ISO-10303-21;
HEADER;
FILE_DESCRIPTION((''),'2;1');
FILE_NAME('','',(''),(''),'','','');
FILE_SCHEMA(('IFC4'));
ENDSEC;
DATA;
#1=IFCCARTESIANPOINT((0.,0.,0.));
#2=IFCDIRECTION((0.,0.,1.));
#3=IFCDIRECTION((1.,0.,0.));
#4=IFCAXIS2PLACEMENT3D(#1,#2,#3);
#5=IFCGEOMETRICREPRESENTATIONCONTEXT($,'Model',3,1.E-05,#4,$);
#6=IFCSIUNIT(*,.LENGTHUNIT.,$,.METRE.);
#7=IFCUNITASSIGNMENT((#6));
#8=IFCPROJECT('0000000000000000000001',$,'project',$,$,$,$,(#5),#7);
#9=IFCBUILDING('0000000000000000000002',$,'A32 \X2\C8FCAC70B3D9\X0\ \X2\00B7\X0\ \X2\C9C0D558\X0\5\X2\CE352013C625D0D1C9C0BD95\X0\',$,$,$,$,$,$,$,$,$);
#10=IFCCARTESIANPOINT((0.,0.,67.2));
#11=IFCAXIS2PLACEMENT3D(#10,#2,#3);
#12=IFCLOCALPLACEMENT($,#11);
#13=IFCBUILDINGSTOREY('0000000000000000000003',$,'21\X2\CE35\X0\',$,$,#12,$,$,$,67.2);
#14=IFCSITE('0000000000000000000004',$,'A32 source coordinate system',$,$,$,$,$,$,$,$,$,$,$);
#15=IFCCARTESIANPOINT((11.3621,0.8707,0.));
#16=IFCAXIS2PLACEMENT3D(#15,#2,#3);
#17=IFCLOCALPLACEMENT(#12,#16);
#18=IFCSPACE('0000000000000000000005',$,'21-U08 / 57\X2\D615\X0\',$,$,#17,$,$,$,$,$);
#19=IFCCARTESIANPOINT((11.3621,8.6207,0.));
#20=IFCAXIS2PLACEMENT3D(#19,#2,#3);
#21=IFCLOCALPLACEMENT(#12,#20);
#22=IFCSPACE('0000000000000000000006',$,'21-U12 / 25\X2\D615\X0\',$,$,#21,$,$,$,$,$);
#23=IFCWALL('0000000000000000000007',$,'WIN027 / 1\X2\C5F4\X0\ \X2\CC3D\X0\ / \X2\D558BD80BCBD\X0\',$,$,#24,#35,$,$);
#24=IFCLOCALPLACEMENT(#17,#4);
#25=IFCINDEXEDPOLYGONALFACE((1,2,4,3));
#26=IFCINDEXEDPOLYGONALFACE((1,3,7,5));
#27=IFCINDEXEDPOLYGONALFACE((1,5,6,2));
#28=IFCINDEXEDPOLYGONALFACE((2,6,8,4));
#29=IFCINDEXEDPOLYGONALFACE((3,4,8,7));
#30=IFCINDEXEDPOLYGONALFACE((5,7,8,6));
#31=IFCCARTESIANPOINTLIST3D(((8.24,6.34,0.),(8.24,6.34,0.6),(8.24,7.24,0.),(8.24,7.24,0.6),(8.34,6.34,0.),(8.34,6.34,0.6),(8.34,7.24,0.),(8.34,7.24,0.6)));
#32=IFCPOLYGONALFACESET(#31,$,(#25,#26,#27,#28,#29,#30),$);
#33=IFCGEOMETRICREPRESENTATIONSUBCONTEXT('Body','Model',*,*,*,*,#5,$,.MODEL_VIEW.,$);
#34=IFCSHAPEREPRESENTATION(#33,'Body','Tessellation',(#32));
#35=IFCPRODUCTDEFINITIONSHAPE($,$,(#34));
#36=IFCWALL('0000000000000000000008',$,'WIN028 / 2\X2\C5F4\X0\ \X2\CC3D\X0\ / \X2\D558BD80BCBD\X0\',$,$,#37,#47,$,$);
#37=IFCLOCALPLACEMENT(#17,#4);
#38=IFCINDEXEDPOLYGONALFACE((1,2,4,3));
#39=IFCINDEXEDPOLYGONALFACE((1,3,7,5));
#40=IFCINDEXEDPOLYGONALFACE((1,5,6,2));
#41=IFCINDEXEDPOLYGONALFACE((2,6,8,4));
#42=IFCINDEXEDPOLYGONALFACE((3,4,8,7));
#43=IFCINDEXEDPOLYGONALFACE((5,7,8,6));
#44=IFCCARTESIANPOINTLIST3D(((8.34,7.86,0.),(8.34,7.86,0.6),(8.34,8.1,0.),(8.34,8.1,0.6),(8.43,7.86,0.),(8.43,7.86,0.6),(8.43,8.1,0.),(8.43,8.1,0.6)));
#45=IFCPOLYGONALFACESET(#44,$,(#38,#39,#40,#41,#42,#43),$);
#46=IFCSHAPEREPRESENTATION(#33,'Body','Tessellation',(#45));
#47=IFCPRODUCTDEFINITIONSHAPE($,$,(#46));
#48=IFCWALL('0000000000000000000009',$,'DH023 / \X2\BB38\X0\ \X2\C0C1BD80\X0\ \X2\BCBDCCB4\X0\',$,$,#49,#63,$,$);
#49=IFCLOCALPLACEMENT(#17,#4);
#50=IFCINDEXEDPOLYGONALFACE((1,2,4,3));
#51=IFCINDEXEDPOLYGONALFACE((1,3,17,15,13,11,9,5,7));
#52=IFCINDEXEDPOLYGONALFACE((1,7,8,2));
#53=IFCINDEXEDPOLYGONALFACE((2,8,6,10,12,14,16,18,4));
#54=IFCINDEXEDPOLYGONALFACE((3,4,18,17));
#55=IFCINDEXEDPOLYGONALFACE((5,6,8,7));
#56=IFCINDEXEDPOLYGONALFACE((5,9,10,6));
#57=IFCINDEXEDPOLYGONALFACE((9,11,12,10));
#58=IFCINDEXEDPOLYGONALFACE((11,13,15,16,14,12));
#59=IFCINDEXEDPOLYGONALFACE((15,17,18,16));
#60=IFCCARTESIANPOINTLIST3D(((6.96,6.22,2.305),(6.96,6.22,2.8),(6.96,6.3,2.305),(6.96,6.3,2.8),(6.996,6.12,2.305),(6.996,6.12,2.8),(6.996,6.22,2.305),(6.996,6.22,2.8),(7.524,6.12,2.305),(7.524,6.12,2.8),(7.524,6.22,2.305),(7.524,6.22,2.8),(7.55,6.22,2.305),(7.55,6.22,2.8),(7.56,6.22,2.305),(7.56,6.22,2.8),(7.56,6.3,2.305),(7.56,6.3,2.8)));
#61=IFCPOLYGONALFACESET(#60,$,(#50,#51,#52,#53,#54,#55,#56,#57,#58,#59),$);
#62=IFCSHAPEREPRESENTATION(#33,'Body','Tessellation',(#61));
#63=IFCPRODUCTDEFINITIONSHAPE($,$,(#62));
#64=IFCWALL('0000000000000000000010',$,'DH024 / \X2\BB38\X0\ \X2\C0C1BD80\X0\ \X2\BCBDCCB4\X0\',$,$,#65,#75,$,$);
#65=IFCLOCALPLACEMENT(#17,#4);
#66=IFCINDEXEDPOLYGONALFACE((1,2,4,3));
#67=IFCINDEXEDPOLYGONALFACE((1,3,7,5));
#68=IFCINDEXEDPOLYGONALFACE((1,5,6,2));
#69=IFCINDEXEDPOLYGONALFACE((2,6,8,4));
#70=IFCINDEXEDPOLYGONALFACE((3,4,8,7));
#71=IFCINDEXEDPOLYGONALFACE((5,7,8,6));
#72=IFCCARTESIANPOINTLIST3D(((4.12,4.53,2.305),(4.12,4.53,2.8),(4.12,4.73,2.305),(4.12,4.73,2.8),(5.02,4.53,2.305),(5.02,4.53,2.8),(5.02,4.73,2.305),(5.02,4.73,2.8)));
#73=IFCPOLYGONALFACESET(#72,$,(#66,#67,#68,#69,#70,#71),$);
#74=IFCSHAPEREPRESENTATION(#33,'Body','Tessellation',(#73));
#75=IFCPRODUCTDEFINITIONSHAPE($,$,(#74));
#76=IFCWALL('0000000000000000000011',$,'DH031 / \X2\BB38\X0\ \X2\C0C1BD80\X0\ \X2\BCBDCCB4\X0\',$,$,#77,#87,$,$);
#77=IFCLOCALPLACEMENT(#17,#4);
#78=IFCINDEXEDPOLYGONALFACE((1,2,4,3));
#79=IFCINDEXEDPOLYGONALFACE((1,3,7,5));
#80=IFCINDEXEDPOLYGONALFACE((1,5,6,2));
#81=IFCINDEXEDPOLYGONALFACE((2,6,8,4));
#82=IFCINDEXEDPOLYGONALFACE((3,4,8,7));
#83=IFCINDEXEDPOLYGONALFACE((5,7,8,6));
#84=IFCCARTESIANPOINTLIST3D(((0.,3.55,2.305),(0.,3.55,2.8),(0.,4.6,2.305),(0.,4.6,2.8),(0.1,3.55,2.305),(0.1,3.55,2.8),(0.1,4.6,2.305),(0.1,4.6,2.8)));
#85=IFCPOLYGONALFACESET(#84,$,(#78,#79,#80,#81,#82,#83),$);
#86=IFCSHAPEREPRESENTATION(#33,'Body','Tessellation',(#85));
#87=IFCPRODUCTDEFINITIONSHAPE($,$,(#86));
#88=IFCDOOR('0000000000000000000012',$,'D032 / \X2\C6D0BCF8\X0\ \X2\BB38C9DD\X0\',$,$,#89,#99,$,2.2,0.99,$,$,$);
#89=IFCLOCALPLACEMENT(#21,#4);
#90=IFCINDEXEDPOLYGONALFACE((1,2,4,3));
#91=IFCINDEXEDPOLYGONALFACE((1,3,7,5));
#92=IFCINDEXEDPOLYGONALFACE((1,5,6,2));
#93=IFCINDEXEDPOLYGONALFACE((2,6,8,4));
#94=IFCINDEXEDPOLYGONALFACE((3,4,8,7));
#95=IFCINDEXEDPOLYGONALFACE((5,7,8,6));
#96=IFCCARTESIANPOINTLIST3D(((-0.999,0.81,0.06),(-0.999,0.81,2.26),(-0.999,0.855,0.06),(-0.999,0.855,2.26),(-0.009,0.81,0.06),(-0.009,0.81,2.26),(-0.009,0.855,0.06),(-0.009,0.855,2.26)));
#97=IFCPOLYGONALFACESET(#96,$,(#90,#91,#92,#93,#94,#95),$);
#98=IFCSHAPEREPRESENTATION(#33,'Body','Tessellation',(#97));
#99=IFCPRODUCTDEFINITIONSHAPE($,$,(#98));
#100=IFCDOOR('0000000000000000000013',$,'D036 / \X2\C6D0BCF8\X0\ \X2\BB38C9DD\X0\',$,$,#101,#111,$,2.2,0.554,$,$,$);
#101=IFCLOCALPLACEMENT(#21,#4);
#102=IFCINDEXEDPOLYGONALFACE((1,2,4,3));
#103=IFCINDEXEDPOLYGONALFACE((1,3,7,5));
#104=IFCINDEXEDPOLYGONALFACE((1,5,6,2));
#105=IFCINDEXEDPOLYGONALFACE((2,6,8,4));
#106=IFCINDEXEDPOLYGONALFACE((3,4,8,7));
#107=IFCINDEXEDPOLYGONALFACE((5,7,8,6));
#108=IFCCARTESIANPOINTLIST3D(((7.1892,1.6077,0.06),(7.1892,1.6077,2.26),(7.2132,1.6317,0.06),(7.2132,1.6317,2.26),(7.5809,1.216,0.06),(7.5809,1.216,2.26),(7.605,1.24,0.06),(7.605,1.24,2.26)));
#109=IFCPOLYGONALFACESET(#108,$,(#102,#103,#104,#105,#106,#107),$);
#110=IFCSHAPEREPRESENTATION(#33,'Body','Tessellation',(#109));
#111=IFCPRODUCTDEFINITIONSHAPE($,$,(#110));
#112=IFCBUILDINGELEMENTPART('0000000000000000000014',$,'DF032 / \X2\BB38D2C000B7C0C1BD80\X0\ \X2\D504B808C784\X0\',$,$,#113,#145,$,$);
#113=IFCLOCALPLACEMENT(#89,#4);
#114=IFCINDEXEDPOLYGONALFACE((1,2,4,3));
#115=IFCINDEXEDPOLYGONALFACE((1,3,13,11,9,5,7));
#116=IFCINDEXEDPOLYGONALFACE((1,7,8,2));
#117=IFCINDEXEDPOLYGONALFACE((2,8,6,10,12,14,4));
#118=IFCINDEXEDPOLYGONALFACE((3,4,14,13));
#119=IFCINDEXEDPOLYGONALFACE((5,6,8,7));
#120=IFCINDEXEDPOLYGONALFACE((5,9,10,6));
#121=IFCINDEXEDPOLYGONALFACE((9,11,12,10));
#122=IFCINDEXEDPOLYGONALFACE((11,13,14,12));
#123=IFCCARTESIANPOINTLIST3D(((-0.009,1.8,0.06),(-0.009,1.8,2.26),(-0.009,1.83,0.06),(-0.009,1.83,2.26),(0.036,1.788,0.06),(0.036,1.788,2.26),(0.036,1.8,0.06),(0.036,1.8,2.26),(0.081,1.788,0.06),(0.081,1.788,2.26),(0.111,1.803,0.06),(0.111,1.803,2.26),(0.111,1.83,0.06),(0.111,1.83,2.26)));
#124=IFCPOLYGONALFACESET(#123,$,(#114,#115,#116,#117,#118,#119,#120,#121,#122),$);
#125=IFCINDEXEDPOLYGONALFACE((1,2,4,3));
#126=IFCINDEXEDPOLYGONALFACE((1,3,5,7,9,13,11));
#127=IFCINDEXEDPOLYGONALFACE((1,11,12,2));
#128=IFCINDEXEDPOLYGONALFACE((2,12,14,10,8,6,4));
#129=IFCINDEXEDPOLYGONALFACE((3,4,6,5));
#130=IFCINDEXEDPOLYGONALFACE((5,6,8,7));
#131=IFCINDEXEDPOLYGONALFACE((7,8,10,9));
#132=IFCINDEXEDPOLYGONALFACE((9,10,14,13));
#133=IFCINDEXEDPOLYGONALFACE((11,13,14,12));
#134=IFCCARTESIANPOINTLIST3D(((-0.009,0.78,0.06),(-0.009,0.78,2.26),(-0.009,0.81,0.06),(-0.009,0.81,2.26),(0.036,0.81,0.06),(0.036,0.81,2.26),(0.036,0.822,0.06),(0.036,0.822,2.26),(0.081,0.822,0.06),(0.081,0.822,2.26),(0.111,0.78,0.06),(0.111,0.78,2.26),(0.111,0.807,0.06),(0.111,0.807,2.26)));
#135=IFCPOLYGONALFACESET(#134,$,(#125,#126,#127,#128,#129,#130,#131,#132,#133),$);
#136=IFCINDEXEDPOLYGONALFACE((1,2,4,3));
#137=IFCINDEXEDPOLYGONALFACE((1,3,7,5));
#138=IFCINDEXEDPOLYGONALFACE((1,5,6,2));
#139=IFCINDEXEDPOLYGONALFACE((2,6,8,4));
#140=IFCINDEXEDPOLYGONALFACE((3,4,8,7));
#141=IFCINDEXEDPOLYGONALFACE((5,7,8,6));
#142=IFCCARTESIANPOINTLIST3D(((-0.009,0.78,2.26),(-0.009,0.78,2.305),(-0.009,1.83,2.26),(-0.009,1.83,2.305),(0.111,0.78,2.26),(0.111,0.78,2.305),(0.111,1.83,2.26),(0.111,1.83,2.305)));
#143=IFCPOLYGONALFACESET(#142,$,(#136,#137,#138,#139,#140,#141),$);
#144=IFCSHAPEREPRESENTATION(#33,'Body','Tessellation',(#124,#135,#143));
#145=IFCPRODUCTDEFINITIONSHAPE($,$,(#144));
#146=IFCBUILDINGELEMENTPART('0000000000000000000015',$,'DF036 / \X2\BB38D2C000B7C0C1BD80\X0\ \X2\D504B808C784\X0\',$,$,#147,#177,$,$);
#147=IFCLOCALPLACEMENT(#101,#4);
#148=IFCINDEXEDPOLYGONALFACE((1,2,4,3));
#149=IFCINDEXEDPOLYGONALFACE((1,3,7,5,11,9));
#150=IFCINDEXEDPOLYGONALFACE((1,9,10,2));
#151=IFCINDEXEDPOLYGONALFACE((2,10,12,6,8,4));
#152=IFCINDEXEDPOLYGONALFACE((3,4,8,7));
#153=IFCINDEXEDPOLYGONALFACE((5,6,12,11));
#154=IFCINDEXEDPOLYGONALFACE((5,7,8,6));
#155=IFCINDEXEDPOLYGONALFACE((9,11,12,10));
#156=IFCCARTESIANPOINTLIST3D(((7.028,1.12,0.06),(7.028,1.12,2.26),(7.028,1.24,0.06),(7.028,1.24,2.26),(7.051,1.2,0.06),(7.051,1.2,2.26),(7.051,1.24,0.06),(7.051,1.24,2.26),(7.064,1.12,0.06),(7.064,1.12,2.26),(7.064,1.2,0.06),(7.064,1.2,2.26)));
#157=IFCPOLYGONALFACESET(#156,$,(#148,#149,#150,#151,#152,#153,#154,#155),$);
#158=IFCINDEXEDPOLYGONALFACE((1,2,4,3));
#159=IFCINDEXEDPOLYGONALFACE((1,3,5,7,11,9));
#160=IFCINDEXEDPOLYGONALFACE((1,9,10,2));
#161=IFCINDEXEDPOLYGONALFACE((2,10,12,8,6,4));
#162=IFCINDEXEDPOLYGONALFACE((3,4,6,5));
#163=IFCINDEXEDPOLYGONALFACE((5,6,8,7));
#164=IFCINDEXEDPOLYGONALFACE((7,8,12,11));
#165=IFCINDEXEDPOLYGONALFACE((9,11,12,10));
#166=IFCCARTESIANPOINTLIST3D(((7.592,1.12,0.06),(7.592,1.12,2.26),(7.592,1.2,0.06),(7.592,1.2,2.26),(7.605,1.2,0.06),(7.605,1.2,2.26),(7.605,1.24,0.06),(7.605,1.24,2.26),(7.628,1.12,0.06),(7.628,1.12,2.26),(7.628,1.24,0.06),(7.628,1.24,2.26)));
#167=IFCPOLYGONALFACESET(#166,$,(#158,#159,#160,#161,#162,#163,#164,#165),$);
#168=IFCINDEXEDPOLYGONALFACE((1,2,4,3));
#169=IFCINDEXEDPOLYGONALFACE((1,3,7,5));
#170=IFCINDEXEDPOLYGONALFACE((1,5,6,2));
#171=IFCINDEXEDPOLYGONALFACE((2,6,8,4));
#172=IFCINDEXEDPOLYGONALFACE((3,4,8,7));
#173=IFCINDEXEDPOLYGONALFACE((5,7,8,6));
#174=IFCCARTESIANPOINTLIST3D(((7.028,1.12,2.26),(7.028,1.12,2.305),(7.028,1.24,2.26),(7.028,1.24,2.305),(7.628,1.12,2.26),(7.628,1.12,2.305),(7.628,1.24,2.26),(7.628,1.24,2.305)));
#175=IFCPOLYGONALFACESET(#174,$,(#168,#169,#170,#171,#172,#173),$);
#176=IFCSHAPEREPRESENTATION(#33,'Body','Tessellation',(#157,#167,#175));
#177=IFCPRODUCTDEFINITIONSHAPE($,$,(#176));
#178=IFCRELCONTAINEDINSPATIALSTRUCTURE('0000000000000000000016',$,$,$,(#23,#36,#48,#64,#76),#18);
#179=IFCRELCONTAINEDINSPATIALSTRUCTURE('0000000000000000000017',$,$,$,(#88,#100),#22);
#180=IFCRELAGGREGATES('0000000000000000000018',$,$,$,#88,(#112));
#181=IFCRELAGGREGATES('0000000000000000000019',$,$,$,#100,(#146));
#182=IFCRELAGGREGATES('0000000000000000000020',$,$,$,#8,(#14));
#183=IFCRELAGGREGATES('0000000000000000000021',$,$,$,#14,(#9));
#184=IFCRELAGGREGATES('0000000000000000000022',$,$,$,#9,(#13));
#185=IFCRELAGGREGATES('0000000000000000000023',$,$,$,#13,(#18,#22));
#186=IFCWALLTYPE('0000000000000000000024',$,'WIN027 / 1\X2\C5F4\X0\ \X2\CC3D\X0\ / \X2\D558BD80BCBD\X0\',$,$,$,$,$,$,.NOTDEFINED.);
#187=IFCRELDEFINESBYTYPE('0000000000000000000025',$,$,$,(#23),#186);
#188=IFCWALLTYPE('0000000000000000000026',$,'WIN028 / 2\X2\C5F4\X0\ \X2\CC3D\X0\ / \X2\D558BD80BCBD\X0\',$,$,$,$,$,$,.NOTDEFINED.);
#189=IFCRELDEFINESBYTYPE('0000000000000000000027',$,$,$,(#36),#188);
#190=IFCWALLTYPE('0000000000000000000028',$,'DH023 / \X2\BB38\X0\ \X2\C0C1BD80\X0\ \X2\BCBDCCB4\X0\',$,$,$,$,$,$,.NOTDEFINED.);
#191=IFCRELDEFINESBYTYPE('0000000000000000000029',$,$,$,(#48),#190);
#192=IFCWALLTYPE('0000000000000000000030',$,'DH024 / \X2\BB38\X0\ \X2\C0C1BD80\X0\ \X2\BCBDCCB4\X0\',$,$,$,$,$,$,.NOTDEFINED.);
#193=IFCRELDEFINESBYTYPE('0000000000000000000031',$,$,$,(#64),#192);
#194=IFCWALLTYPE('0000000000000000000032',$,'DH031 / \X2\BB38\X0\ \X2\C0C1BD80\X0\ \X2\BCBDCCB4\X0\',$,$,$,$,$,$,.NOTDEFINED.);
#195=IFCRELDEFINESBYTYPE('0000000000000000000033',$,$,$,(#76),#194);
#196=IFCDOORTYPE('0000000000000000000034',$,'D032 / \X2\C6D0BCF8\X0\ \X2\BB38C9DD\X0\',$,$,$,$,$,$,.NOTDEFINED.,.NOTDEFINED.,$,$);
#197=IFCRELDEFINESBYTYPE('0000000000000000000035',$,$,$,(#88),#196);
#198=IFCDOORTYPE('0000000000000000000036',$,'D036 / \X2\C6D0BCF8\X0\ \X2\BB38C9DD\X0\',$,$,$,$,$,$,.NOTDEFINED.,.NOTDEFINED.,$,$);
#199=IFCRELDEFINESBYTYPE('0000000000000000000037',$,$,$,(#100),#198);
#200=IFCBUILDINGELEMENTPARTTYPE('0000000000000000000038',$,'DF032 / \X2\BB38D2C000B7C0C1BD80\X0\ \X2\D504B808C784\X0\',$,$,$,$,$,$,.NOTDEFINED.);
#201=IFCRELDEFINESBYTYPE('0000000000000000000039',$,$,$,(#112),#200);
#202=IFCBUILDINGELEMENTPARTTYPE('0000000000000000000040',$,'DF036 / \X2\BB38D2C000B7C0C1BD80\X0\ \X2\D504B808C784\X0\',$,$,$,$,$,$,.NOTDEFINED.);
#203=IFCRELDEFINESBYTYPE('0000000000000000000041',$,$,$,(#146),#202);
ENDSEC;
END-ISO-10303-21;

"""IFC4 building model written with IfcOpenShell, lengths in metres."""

from ifc_helpers import new_model, si_unit, frame, origin, origin_with_axes, place, context, subcontext, project, spatial, polyline, outline, extrude, source, transform, mapped, type_object, type_shapes, element, aggregate, save


model = new_model("IFC4")

# Units and contexts
model_context = context("Model", 3, precision=1e-05, world=origin_with_axes())
body_context = subcontext(model_context, "Body", "Model", "MODEL_VIEW")
ifc_project = project(units=[si_unit("LENGTHUNIT", "METRE")], contexts=[model_context])

# Site, building, storey, space
storey_placement = place(None, frame((0.0, 0.0, 67.2), z_axis=(0.0, 0.0, 1.0), x_axis=(1.0, 0.0, 0.0)))
space_1_placement = place(storey_placement, frame((11.3621, 8.6207, 0.0), z_axis=(0.0, 0.0, 1.0), x_axis=(1.0, 0.0, 0.0)))
site = spatial("IfcSite", under=ifc_project, Name="A32 source coordinate system")
building = spatial("IfcBuilding", under=site, Name="A32 주거동 · 지하5층–옥탑지붕")
storey = spatial("IfcBuildingStorey", under=building, at=storey_placement, Name="21층", Elevation=67.2)
space_2_placement = place(storey_placement, frame((11.3621, 0.8707, 0.0), z_axis=(0.0, 0.0, 1.0), x_axis=(1.0, 0.0, 0.0)))
space_2 = spatial("IfcSpace", under=storey, at=space_2_placement, Name="21-U08 / 57형")

# Walls
wall_type_1 = type_object("IfcWallType", Name="WIN027 / 1열 창 / 하부벽", PredefinedType="NOTDEFINED")
shared_shape_1 = source(origin(), body_context, "Body", "SweptSolid", [
    extrude(outline(polyline([(8.24, 6.34), (8.24, 7.24), (8.34, 7.24), (8.34, 6.34), (8.24, 6.34)])), origin(), (0.0, 0.0, 1.0), 0.6),
])
type_shapes(wall_type_1, [shared_shape_1])
wall_1_placement = place(space_2_placement, origin_with_axes())
element("IfcWall", 1, at=wall_1_placement, inside=space_2, type_object=wall_type_1, Name="WIN027 / 1열 창 / 하부벽", context=body_context, shape_type="MappedRepresentation", body=[
    mapped(shared_shape_1, transform((0.0, 0.0, 0.0), scale=1.0)),
])
wall_type_2 = type_object("IfcWallType", Name="WIN028 / 2열 창 / 하부벽", PredefinedType="NOTDEFINED")
shared_shape_2 = source(origin(), body_context, "Body", "SweptSolid", [
    extrude(outline(polyline([(8.34, 7.86), (8.34, 8.1), (8.43, 8.1), (8.43, 7.86), (8.34, 7.86)])), origin(), (0.0, 0.0, 1.0), 0.6),
])
type_shapes(wall_type_2, [shared_shape_2])
wall_2_placement = place(space_2_placement, origin_with_axes())
element("IfcWall", 2, at=wall_2_placement, inside=space_2, type_object=wall_type_2, Name="WIN028 / 2열 창 / 하부벽", context=body_context, shape_type="MappedRepresentation", body=[
    mapped(shared_shape_2, transform((0.0, 0.0, 0.0), scale=1.0)),
])
wall_type_3 = type_object("IfcWallType", Name="DH023 / 문 상부 벽체", PredefinedType="NOTDEFINED")
shared_shape_3 = source(origin(), body_context, "Body", "SweptSolid", [
    extrude(outline(polyline([(6.96, 6.3), (7.56, 6.3), (7.56, 6.22), (7.55, 6.22), (7.524, 6.22), (7.524, 6.12), (6.996, 6.12), (6.996, 6.22), (6.96, 6.22), (6.96, 6.3)])), frame((0.0, 0.0, 2.305)), (0.0, 0.0, 1.0), 0.495),
])
type_shapes(wall_type_3, [shared_shape_3])
wall_3_placement = place(space_2_placement, origin_with_axes())
element("IfcWall", 3, at=wall_3_placement, inside=space_2, type_object=wall_type_3, Name="DH023 / 문 상부 벽체", context=body_context, shape_type="MappedRepresentation", body=[
    mapped(shared_shape_3, transform((0.0, 0.0, 0.0), scale=1.0)),
])
wall_type_4 = type_object("IfcWallType", Name="DH024 / 문 상부 벽체", PredefinedType="NOTDEFINED")
shared_shape_4 = source(origin(), body_context, "Body", "SweptSolid", [
    extrude(outline(polyline([(4.12, 4.73), (5.02, 4.73), (5.02, 4.53), (4.12, 4.53), (4.12, 4.73)])), frame((0.0, 0.0, 2.305)), (0.0, 0.0, 1.0), 0.495),
])
type_shapes(wall_type_4, [shared_shape_4])
wall_4_placement = place(space_2_placement, origin_with_axes())
element("IfcWall", 4, at=wall_4_placement, inside=space_2, type_object=wall_type_4, Name="DH024 / 문 상부 벽체", context=body_context, shape_type="MappedRepresentation", body=[
    mapped(shared_shape_4, transform((0.0, 0.0, 0.0), scale=1.0)),
])
wall_type_5 = type_object("IfcWallType", Name="DH031 / 문 상부 벽체", PredefinedType="NOTDEFINED")
shared_shape_5 = source(origin(), body_context, "Body", "SweptSolid", [
    extrude(outline(polyline([(0.0, 4.6), (0.1, 4.6), (0.1, 3.55), (0.0, 3.55), (0.0, 4.6)])), frame((0.0, 0.0, 2.305)), (0.0, 0.0, 1.0), 0.495),
])
type_shapes(wall_type_5, [shared_shape_5])
wall_5_placement = place(space_2_placement, origin_with_axes())
element("IfcWall", 5, at=wall_5_placement, inside=space_2, type_object=wall_type_5, Name="DH031 / 문 상부 벽체", context=body_context, shape_type="MappedRepresentation", body=[
    mapped(shared_shape_5, transform((0.0, 0.0, 0.0), scale=1.0)),
])

# Shared definitions
space_1 = spatial("IfcSpace", under=storey, at=space_1_placement, Name="21-U12 / 25형")

# Doors
door_type_1 = type_object("IfcDoorType", Name="D032 / 원본 문짝", OperationType="NOTDEFINED", PredefinedType="NOTDEFINED")
shared_shape_6 = source(origin(), body_context, "Body", "SweptSolid", [
    extrude(outline(polyline([(-0.009, 0.81), (-0.999, 0.81), (-0.999, 0.855), (-0.009, 0.855), (-0.009, 0.81)])), frame((0.0, 0.0, 0.06)), (0.0, 0.0, 1.0), 2.2),
])
type_shapes(door_type_1, [shared_shape_6])
door_1_placement = place(space_1_placement, origin_with_axes())
door_1 = element("IfcDoor", 6, at=door_1_placement, inside=space_1, type_object=door_type_1, Name="D032 / 원본 문짝", OverallHeight=2.2, OverallWidth=0.99, context=body_context, shape_type="MappedRepresentation", body=[
    mapped(shared_shape_6, transform((0.0, 0.0, 0.0), scale=1.0)),
])
door_type_2 = type_object("IfcDoorType", Name="D036 / 원본 문짝", OperationType="NOTDEFINED", PredefinedType="NOTDEFINED")
shared_shape_7 = source(origin(), body_context, "Body", "SweptSolid", [
    extrude(outline(polyline([(7.1892, 1.6077), (7.2132, 1.6317), (7.605, 1.24), (7.5809, 1.216), (7.1892, 1.6077)])), frame((0.0, 0.0, 0.06)), (0.0, 0.0, 1.0), 2.2),
])
type_shapes(door_type_2, [shared_shape_7])
door_2_placement = place(space_1_placement, origin_with_axes())
door_2 = element("IfcDoor", 7, at=door_2_placement, inside=space_1, type_object=door_type_2, Name="D036 / 원본 문짝", OverallHeight=2.2, OverallWidth=0.554, context=body_context, shape_type="MappedRepresentation", body=[
    mapped(shared_shape_7, transform((0.0, 0.0, 0.0), scale=1.0)),
])

# Building element parts
building_element_part_type_1 = type_object("IfcBuildingElementPartType", Name="DF032 / 문틀·상부 프레임", PredefinedType="NOTDEFINED")
shared_shape_8 = source(origin(), body_context, "Body", "SweptSolid", [
    extrude(outline(polyline([(0.111, 1.83), (0.111, 1.803), (0.081, 1.788), (0.036, 1.788), (0.036, 1.8), (-0.009, 1.8), (-0.009, 1.83), (0.111, 1.83)])), frame((0.0, 0.0, 0.06)), (0.0, 0.0, 1.0), 2.2),
    extrude(outline(polyline([(-0.009, 0.81), (0.036, 0.81), (0.036, 0.822), (0.081, 0.822), (0.111, 0.807), (0.111, 0.78), (-0.009, 0.78), (-0.009, 0.81)])), frame((0.0, 0.0, 0.06)), (0.0, 0.0, 1.0), 2.2),
    extrude(outline(polyline([(-0.009, 0.78), (-0.009, 1.83), (0.111, 1.83), (0.111, 0.78), (-0.009, 0.78)])), frame((0.0, 0.0, 2.26)), (0.0, 0.0, 1.0), 0.045),
])
type_shapes(building_element_part_type_1, [shared_shape_8])
building_element_part_1_placement = place(door_1_placement, origin_with_axes())
building_element_part_1 = element("IfcBuildingElementPart", 8, at=building_element_part_1_placement, type_object=building_element_part_type_1, Name="DF032 / 문틀·상부 프레임", context=body_context, shape_type="MappedRepresentation", body=[
    mapped(shared_shape_8, transform((0.0, 0.0, 0.0), scale=1.0)),
])
aggregate(door_1, [building_element_part_1])
building_element_part_type_2 = type_object("IfcBuildingElementPartType", Name="DF036 / 문틀·상부 프레임", PredefinedType="NOTDEFINED")
shared_shape_9 = source(origin(), body_context, "Body", "SweptSolid", [
    extrude(outline(polyline([(7.028, 1.24), (7.051, 1.24), (7.051, 1.2), (7.064, 1.2), (7.064, 1.12), (7.028, 1.12), (7.028, 1.24)])), frame((0.0, 0.0, 0.06)), (0.0, 0.0, 1.0), 2.2),
    extrude(outline(polyline([(7.592, 1.12), (7.592, 1.2), (7.605, 1.2), (7.605, 1.24), (7.628, 1.24), (7.628, 1.12), (7.592, 1.12)])), frame((0.0, 0.0, 0.06)), (0.0, 0.0, 1.0), 2.2),
    extrude(outline(polyline([(7.028, 1.12), (7.028, 1.24), (7.628, 1.24), (7.628, 1.12), (7.028, 1.12)])), frame((0.0, 0.0, 2.26)), (0.0, 0.0, 1.0), 0.045),
])
type_shapes(building_element_part_type_2, [shared_shape_9])
building_element_part_2_placement = place(door_2_placement, origin_with_axes())
building_element_part_2 = element("IfcBuildingElementPart", 9, at=building_element_part_2_placement, type_object=building_element_part_type_2, Name="DF036 / 문틀·상부 프레임", context=body_context, shape_type="MappedRepresentation", body=[
    mapped(shared_shape_9, transform((0.0, 0.0, 0.0), scale=1.0)),
])
aggregate(door_2, [building_element_part_2])

save(model, "model.ifc")
